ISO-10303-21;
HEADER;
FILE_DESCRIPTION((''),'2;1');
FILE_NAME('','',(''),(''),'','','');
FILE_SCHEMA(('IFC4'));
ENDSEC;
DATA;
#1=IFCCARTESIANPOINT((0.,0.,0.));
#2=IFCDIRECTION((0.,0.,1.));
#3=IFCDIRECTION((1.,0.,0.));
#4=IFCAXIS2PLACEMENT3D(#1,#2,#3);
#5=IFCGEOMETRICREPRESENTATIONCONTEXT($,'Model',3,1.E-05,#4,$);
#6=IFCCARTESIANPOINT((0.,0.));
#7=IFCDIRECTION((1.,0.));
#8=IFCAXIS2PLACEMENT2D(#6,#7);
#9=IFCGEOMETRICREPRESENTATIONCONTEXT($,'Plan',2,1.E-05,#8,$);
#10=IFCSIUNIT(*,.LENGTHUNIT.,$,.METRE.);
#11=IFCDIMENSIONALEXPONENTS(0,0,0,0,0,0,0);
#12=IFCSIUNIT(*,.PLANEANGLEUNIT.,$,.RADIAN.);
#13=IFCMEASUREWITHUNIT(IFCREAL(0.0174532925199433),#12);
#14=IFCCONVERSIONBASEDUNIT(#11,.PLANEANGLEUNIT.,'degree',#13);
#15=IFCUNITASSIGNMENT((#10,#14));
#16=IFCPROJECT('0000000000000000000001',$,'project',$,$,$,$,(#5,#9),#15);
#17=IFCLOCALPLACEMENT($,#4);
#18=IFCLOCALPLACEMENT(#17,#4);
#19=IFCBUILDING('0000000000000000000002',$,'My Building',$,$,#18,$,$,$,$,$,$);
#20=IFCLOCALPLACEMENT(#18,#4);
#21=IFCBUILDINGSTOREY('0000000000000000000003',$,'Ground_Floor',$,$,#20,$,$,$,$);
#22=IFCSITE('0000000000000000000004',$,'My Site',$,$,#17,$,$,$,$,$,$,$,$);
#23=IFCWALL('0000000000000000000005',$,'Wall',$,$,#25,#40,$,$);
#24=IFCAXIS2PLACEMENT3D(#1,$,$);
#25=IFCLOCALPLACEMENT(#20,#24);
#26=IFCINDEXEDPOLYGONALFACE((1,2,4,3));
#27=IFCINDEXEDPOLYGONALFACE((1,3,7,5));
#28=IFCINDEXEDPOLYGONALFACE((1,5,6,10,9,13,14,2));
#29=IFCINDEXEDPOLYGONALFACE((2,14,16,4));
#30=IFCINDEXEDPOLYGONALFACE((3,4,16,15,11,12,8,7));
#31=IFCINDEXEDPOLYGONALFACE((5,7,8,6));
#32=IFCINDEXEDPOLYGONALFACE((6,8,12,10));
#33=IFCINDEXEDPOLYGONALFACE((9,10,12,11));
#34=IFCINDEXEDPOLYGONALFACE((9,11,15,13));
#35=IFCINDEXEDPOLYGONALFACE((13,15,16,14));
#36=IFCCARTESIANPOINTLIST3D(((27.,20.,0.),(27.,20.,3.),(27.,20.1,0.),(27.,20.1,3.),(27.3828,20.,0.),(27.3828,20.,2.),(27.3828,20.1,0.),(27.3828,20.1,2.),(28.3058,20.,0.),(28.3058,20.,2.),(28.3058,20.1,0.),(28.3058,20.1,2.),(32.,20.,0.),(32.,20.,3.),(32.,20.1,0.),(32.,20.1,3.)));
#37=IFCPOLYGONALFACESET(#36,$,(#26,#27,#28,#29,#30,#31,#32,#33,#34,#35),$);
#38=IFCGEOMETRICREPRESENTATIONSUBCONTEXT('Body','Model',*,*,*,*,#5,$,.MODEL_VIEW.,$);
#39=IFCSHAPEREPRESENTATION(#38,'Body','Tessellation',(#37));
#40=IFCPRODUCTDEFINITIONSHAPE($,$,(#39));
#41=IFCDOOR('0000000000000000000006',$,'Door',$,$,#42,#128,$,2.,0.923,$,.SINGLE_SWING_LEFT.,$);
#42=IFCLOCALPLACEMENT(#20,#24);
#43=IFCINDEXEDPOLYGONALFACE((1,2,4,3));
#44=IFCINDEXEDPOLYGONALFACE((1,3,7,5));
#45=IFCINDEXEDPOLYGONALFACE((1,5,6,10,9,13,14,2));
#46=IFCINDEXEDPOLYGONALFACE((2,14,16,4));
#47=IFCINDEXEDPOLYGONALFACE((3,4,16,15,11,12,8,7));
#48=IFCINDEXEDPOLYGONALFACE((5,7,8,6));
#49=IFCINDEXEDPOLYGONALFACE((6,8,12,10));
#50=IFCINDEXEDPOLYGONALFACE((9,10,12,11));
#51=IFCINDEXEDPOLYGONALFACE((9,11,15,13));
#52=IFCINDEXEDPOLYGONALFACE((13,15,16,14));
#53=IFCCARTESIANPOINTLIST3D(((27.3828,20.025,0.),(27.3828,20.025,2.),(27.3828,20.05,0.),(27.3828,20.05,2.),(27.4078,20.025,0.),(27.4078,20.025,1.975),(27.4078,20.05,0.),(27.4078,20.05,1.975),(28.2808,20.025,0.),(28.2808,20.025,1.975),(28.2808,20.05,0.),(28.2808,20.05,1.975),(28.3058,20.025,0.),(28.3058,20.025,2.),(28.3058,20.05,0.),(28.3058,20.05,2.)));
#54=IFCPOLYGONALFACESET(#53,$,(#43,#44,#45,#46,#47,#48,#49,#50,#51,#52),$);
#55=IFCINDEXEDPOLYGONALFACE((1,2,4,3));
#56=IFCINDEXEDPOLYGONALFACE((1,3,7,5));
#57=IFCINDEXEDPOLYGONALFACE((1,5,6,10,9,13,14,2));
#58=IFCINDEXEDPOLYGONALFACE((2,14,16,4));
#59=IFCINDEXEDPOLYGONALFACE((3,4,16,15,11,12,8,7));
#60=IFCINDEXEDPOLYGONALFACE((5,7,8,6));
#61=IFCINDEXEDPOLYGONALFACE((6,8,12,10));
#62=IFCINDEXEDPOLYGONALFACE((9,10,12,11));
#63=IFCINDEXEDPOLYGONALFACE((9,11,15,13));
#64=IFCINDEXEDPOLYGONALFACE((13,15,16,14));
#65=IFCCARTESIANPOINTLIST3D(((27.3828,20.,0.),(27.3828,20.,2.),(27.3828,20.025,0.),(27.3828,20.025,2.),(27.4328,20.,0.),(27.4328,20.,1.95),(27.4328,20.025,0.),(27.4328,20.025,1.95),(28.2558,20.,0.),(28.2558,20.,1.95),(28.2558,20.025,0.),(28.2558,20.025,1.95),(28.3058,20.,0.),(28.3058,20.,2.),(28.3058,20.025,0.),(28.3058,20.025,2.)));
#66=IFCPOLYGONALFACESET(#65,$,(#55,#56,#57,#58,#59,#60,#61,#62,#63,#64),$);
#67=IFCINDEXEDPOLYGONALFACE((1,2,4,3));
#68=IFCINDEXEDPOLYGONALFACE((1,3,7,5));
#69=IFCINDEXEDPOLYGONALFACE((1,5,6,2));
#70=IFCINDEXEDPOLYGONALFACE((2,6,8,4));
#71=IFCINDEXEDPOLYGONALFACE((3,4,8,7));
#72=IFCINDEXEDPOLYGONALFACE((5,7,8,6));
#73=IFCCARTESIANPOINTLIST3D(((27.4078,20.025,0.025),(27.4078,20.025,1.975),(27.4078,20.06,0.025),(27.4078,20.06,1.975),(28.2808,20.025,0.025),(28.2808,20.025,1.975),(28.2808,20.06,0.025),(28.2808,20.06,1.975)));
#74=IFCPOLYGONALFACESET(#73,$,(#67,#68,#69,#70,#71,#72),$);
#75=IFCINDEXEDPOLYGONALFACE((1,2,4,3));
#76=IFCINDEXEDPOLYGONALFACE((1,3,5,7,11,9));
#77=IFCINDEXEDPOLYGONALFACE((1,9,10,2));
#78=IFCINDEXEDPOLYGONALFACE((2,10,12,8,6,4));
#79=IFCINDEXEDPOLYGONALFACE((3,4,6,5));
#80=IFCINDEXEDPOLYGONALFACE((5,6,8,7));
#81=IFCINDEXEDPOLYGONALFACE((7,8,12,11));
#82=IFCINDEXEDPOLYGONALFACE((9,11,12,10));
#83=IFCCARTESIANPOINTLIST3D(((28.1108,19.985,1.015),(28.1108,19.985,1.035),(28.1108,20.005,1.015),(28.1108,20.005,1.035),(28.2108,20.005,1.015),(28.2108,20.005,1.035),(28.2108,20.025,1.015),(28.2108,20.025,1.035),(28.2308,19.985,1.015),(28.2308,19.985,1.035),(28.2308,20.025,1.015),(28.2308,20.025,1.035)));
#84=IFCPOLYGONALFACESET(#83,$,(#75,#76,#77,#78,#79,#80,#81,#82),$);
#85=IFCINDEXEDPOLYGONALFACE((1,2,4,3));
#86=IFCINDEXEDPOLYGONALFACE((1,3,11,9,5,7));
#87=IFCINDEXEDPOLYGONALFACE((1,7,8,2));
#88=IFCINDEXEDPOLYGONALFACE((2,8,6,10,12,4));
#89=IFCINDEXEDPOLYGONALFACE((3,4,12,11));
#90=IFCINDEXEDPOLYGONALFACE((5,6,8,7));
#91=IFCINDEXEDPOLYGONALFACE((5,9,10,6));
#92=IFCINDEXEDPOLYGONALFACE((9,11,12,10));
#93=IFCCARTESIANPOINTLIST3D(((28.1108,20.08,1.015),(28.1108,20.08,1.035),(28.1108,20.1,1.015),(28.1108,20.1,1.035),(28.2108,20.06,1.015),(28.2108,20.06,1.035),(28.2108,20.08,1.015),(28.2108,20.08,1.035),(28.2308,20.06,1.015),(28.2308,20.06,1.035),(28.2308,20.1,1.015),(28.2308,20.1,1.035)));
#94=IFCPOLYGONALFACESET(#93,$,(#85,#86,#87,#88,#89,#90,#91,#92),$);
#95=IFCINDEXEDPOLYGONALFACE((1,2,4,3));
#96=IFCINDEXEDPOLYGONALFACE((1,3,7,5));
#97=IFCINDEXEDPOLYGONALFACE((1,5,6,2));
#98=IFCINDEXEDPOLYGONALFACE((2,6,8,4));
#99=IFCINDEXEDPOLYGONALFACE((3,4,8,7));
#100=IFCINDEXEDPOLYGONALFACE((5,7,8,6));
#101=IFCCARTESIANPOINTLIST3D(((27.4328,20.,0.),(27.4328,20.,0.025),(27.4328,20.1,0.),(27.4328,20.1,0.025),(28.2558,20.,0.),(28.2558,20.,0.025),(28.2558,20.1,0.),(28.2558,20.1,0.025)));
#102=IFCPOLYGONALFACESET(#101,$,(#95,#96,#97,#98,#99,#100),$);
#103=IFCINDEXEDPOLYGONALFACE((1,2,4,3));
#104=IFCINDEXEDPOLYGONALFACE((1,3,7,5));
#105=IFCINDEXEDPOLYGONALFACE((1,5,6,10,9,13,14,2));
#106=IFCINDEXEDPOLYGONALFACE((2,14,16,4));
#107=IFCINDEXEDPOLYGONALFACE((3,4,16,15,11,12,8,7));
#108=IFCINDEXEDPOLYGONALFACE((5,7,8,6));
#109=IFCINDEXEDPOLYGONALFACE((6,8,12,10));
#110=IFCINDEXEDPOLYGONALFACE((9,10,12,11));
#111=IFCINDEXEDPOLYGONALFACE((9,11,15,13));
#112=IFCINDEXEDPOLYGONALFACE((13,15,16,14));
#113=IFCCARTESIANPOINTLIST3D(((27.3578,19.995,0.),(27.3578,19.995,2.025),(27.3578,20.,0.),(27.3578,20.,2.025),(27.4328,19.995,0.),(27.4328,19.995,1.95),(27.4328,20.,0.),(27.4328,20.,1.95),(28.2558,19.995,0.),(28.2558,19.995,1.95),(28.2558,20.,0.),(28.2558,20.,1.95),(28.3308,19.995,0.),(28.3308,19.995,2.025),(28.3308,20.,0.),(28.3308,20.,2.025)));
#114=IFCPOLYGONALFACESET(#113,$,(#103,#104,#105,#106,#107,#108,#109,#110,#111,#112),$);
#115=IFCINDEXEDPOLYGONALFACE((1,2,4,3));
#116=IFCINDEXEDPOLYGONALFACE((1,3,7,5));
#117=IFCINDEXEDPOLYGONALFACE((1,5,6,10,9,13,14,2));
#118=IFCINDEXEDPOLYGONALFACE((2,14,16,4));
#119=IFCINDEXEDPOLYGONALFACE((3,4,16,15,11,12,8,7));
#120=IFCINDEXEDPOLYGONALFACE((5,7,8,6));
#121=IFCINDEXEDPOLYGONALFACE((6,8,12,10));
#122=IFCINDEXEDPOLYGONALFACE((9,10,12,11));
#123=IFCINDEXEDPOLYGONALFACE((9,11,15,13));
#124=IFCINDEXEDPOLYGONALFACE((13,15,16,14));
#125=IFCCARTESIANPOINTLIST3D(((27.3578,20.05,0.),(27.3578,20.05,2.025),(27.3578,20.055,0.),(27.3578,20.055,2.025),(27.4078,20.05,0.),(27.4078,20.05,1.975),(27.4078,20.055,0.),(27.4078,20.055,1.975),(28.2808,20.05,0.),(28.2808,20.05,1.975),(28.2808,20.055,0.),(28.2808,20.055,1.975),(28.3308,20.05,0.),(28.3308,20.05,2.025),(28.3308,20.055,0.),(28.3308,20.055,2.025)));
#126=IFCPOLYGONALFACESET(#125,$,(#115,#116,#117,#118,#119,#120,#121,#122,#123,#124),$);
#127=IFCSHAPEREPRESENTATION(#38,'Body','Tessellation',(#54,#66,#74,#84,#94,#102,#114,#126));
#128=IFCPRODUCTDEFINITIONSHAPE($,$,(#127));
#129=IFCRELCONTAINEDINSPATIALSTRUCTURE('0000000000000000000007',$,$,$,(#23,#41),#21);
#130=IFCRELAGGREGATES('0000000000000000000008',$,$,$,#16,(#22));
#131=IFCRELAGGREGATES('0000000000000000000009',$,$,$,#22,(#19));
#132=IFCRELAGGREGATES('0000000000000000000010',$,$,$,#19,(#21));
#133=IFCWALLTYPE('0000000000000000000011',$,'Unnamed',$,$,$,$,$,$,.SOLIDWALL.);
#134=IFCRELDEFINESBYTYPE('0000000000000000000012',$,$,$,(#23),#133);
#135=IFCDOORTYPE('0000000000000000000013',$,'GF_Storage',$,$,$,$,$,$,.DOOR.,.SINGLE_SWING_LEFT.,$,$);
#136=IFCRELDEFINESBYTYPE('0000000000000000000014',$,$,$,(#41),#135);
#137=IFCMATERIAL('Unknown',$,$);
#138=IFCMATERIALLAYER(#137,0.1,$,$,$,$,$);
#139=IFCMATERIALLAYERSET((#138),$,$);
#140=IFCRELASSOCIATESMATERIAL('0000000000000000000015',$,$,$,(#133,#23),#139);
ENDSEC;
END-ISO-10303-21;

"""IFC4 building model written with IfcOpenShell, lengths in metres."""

from ifc_helpers import new_model, entity, si_unit, converted_unit, frame, origin_with_axes, origin_2d_with_axis, place, context, subcontext, project, spatial, line, indexed_curve, outline, extrude, shape, source, transform, mapped, material, layer, layer_set, layer_usage, type_object, type_shapes, element, fill, save


model = new_model("IFC4")

# Units and contexts
model_context = context("Model", 3, precision=1e-05, world=origin_with_axes())
plan_context = context("Plan", 2, precision=1e-05, world=origin_2d_with_axis())
body_context_1 = subcontext(model_context, "Body", "Model", "MODEL_VIEW")
body_context_2 = subcontext(plan_context, "Body", "Plan", "PLAN_VIEW")
ifc_project = project(units=[si_unit("LENGTHUNIT", "METRE"), converted_unit("PLANEANGLEUNIT", "degree", entity("IfcReal", 0.0174532925199433), si_unit("PLANEANGLEUNIT", "RADIAN"), dimensions=[0, 0, 0, 0, 0, 0, 0])], contexts=[model_context, plan_context])

# Site, building, storey
site_placement = place(None, origin_with_axes())
site = spatial("IfcSite", under=ifc_project, at=site_placement, Name="My Site")
building_placement = place(site_placement, origin_with_axes())
building = spatial("IfcBuilding", under=site, at=building_placement, Name="My Building")
storey_placement = place(building_placement, origin_with_axes())
storey = spatial("IfcBuildingStorey", under=building, at=storey_placement, Name="Ground_Floor")

# Shared definitions
ifc_material = material(Name="Unknown")
ifc_layer = layer(ifc_material, 0.1)
ifc_layer_set = layer_set([ifc_layer])
wall_type = type_object("IfcWallType", Name="Unnamed", PredefinedType="SOLIDWALL", material=ifc_layer_set)

# Wall, opening, door
ifc_layer_usage_1 = layer_usage(ifc_layer_set, "AXIS2", "POSITIVE", 0.0)
wall_1_placement = place(storey_placement, frame((27.0, 20.0, 0.0), z_axis=(0.0, 0.0, 1.0), x_axis=(1.0, 0.0, 0.0)))
wall_1 = element("IfcWall", 1, at=wall_1_placement, inside=storey, type_object=wall_type, material=ifc_layer_usage_1, Name="Wall", context=body_context_1, shape_type="SweptSolid", body=[
    extrude(outline(indexed_curve([(0.0, 0.0), (0.0, 0.1), (5.0, 0.1), (5.0, 0.0)], segments=[line(1, 2, 3, 4, 1)])), origin_with_axes(), (0.0, 0.0, 1.0), 3.0),
])
shared_shape_1 = source(origin_with_axes(), body_context_1, "Body", "SweptSolid", [
    extrude(outline(indexed_curve([(0.0, 0.0), (0.923, 0.0), (0.923, 2.0), (0.0, 2.0)], segments=[line(1, 2, 3, 4, 1)])), frame((0.0, -0.6, 0.0), z_axis=(0.0, -1.0, 0.0), x_axis=(1.0, 0.0, 0.0)), (0.0, 0.0, -1.0), 1.2),
])
opening_1_placement = place(wall_1_placement, frame((0.3828, 0.0, 0.0), z_axis=(0.0, 0.0, 1.0), x_axis=(1.0, 0.0, 0.0)))
opening_1 = element("IfcOpeningElement", 2, at=opening_1_placement, cuts=wall_1, PredefinedType="OPENING", context=body_context_1, shape_type="MappedRepresentation", body=[
    mapped(shared_shape_1, transform((0.0, 0.0, 0.0), x_axis=(1.0, 0.0, 0.0), y_axis=(0.0, 1.0, 0.0), z_axis=(0.0, 0.0, 1.0), scale=1.0)),
])
door_type_1 = type_object("IfcDoorType", Name="GF_Storage", OperationType="SINGLE_SWING_LEFT", PredefinedType="DOOR")
shared_shape_2 = source(origin_with_axes(), body_context_1, "Body", "SweptSolid", [
    extrude(outline(indexed_curve([(0.0, 0.0), (0.0, 2.0), (0.923, 2.0), (0.923, 0.0), (0.898, 0.0), (0.898, 1.975), (0.025, 1.975), (0.025, 0.0)], segments=[line(1, 2, 3, 4, 5, 6, 7, 8, 1)])), frame((0.0, 0.025, 0.0), z_axis=(0.0, -1.0, 0.0), x_axis=(1.0, 0.0, 0.0)), (0.0, 0.0, -1.0), 0.025),
    extrude(outline(indexed_curve([(0.0, 0.0), (0.0, 2.0), (0.923, 2.0), (0.923, 0.0), (0.873, 0.0), (0.873, 1.95), (0.05, 1.95), (0.05, 0.0)], segments=[line(1, 2, 3, 4, 5, 6, 7, 8, 1)])), frame((0.0, 0.0, 0.0), z_axis=(0.0, -1.0, 0.0), x_axis=(1.0, 0.0, 0.0)), (0.0, 0.0, -1.0), 0.025),
    extrude(outline(indexed_curve([(0.0, 0.0), (0.873, 0.0), (0.873, 0.035), (0.0, 0.035)], segments=[line(1, 2, 3, 4, 1)])), frame((0.025, 0.025, 0.025), z_axis=(0.0, 0.0, 1.0), x_axis=(1.0, 0.0, 0.0)), (0.0, 0.0, 1.0), 1.95),
    extrude(outline(indexed_curve([(0.0, 0.0), (0.0, -0.04), (-0.12, -0.04), (-0.12, -0.02), (-0.02, -0.02), (-0.02, 0.0)], segments=[line(1, 2, 3, 4, 5, 6, 1)])), frame((0.848, 0.025, 1.015), z_axis=(0.0, 0.0, 1.0), x_axis=(1.0, 0.0, 0.0)), (0.0, 0.0, 1.0), 0.02),
    extrude(outline(indexed_curve([(0.0, 0.0), (0.0, 0.04), (-0.12, 0.04), (-0.12, 0.02), (-0.02, 0.02), (-0.02, 0.0)], segments=[line(1, 2, 3, 4, 5, 6, 1)])), frame((0.848, 0.06, 1.015), z_axis=(0.0, 0.0, 1.0), x_axis=(1.0, 0.0, 0.0)), (0.0, 0.0, 1.0), 0.02),
    extrude(outline(indexed_curve([(0.0, 0.0), (0.823, 0.0), (0.823, 0.1), (0.0, 0.1)], segments=[line(1, 2, 3, 4, 1)])), frame((0.05, 0.0, 0.0), z_axis=(0.0, 0.0, 1.0), x_axis=(1.0, 0.0, 0.0)), (0.0, 0.0, 1.0), 0.025),
    extrude(outline(indexed_curve([(0.0, 0.0), (0.0, 2.025), (0.973, 2.025), (0.973, 0.0), (0.898, 0.0), (0.898, 1.95), (0.075, 1.95), (0.075, 0.0)], segments=[line(1, 2, 3, 4, 5, 6, 7, 8, 1)])), frame((-0.025, -0.005, 0.0), z_axis=(0.0, -1.0, 0.0), x_axis=(1.0, 0.0, 0.0)), (0.0, 0.0, -1.0), 0.005),
    extrude(outline(indexed_curve([(0.0, 0.0), (0.0, 2.025), (0.973, 2.025), (0.973, 0.0), (0.923, 0.0), (0.923, 1.975), (0.05, 1.975), (0.05, 0.0)], segments=[line(1, 2, 3, 4, 5, 6, 7, 8, 1)])), frame((-0.025, 0.05, 0.0), z_axis=(0.0, -1.0, 0.0), x_axis=(1.0, 0.0, 0.0)), (0.0, 0.0, -1.0), 0.005),
])
shared_shape_3 = source(origin_with_axes(), body_context_2, "Body", "Curve2D", [
    entity("IfcIndexedPolyCurve", entity("IfcCartesianPointList2D", [[0.0, 0.0], [0.0, 0.05], [0.025, 0.05], [0.025, 0.025], [0.05, 0.025], [0.05, 0.0]]), [entity("IfcLineIndex", [1, 2, 3, 4, 5, 6, 1])]),
    entity("IfcIndexedPolyCurve", entity("IfcCartesianPointList2D", [[0.923, 0.0], [0.923, 0.05], [0.898, 0.05], [0.898, 0.025], [0.873, 0.025], [0.873, 0.0]]), [entity("IfcLineIndex", [1, 2, 3, 4, 5, 6, 1])]),
    entity("IfcTrimmedCurve", entity("IfcEllipse", entity("IfcAxis2Placement2D", entity("IfcCartesianPoint", [0.06, 0.05]), entity("IfcDirection", [1.0, 0.0])), 0.838, 0.873), [entity("IfcCartesianPoint", [0.898, 0.05])], [entity("IfcCartesianPoint", [0.06, 0.923])], True, "CARTESIAN"),
    entity("IfcIndexedPolyCurve", entity("IfcCartesianPointList2D", [[0.025, 0.05], [0.06, 0.05], [0.06, 0.923], [0.025, 0.923]]), [entity("IfcLineIndex", [1, 2, 3, 4, 1])]),
])
type_shapes(door_type_1, [shared_shape_2, shared_shape_3])
door_1_placement = place(opening_1_placement, frame((0.0, 0.0, 0.0), z_axis=(0.0, 0.0, 1.0), x_axis=(1.0, 0.0, 0.0)))
door_1 = element("IfcDoor", 3, at=door_1_placement, inside=storey, type_object=door_type_1, Name="Door", OperationType="SINGLE_SWING_LEFT", OverallHeight=2.0, OverallWidth=0.923, shapes=[
    shape(body_context_1, "Body", "MappedRepresentation", [mapped(shared_shape_2, transform((0.0, 0.0, 0.0), x_axis=(1.0, 0.0, 0.0), y_axis=(0.0, 1.0, 0.0), z_axis=(0.0, 0.0, 1.0), scale=1.0))]),
    shape(body_context_2, "Body", "MappedRepresentation", [mapped(shared_shape_3, transform((0.0, 0.0, 0.0), x_axis=(1.0, 0.0, 0.0), y_axis=(0.0, 1.0, 0.0), z_axis=(0.0, 0.0, 1.0), scale=1.0))]),
])
fill(opening_1, door_1)

save(model, "model.ifc")
